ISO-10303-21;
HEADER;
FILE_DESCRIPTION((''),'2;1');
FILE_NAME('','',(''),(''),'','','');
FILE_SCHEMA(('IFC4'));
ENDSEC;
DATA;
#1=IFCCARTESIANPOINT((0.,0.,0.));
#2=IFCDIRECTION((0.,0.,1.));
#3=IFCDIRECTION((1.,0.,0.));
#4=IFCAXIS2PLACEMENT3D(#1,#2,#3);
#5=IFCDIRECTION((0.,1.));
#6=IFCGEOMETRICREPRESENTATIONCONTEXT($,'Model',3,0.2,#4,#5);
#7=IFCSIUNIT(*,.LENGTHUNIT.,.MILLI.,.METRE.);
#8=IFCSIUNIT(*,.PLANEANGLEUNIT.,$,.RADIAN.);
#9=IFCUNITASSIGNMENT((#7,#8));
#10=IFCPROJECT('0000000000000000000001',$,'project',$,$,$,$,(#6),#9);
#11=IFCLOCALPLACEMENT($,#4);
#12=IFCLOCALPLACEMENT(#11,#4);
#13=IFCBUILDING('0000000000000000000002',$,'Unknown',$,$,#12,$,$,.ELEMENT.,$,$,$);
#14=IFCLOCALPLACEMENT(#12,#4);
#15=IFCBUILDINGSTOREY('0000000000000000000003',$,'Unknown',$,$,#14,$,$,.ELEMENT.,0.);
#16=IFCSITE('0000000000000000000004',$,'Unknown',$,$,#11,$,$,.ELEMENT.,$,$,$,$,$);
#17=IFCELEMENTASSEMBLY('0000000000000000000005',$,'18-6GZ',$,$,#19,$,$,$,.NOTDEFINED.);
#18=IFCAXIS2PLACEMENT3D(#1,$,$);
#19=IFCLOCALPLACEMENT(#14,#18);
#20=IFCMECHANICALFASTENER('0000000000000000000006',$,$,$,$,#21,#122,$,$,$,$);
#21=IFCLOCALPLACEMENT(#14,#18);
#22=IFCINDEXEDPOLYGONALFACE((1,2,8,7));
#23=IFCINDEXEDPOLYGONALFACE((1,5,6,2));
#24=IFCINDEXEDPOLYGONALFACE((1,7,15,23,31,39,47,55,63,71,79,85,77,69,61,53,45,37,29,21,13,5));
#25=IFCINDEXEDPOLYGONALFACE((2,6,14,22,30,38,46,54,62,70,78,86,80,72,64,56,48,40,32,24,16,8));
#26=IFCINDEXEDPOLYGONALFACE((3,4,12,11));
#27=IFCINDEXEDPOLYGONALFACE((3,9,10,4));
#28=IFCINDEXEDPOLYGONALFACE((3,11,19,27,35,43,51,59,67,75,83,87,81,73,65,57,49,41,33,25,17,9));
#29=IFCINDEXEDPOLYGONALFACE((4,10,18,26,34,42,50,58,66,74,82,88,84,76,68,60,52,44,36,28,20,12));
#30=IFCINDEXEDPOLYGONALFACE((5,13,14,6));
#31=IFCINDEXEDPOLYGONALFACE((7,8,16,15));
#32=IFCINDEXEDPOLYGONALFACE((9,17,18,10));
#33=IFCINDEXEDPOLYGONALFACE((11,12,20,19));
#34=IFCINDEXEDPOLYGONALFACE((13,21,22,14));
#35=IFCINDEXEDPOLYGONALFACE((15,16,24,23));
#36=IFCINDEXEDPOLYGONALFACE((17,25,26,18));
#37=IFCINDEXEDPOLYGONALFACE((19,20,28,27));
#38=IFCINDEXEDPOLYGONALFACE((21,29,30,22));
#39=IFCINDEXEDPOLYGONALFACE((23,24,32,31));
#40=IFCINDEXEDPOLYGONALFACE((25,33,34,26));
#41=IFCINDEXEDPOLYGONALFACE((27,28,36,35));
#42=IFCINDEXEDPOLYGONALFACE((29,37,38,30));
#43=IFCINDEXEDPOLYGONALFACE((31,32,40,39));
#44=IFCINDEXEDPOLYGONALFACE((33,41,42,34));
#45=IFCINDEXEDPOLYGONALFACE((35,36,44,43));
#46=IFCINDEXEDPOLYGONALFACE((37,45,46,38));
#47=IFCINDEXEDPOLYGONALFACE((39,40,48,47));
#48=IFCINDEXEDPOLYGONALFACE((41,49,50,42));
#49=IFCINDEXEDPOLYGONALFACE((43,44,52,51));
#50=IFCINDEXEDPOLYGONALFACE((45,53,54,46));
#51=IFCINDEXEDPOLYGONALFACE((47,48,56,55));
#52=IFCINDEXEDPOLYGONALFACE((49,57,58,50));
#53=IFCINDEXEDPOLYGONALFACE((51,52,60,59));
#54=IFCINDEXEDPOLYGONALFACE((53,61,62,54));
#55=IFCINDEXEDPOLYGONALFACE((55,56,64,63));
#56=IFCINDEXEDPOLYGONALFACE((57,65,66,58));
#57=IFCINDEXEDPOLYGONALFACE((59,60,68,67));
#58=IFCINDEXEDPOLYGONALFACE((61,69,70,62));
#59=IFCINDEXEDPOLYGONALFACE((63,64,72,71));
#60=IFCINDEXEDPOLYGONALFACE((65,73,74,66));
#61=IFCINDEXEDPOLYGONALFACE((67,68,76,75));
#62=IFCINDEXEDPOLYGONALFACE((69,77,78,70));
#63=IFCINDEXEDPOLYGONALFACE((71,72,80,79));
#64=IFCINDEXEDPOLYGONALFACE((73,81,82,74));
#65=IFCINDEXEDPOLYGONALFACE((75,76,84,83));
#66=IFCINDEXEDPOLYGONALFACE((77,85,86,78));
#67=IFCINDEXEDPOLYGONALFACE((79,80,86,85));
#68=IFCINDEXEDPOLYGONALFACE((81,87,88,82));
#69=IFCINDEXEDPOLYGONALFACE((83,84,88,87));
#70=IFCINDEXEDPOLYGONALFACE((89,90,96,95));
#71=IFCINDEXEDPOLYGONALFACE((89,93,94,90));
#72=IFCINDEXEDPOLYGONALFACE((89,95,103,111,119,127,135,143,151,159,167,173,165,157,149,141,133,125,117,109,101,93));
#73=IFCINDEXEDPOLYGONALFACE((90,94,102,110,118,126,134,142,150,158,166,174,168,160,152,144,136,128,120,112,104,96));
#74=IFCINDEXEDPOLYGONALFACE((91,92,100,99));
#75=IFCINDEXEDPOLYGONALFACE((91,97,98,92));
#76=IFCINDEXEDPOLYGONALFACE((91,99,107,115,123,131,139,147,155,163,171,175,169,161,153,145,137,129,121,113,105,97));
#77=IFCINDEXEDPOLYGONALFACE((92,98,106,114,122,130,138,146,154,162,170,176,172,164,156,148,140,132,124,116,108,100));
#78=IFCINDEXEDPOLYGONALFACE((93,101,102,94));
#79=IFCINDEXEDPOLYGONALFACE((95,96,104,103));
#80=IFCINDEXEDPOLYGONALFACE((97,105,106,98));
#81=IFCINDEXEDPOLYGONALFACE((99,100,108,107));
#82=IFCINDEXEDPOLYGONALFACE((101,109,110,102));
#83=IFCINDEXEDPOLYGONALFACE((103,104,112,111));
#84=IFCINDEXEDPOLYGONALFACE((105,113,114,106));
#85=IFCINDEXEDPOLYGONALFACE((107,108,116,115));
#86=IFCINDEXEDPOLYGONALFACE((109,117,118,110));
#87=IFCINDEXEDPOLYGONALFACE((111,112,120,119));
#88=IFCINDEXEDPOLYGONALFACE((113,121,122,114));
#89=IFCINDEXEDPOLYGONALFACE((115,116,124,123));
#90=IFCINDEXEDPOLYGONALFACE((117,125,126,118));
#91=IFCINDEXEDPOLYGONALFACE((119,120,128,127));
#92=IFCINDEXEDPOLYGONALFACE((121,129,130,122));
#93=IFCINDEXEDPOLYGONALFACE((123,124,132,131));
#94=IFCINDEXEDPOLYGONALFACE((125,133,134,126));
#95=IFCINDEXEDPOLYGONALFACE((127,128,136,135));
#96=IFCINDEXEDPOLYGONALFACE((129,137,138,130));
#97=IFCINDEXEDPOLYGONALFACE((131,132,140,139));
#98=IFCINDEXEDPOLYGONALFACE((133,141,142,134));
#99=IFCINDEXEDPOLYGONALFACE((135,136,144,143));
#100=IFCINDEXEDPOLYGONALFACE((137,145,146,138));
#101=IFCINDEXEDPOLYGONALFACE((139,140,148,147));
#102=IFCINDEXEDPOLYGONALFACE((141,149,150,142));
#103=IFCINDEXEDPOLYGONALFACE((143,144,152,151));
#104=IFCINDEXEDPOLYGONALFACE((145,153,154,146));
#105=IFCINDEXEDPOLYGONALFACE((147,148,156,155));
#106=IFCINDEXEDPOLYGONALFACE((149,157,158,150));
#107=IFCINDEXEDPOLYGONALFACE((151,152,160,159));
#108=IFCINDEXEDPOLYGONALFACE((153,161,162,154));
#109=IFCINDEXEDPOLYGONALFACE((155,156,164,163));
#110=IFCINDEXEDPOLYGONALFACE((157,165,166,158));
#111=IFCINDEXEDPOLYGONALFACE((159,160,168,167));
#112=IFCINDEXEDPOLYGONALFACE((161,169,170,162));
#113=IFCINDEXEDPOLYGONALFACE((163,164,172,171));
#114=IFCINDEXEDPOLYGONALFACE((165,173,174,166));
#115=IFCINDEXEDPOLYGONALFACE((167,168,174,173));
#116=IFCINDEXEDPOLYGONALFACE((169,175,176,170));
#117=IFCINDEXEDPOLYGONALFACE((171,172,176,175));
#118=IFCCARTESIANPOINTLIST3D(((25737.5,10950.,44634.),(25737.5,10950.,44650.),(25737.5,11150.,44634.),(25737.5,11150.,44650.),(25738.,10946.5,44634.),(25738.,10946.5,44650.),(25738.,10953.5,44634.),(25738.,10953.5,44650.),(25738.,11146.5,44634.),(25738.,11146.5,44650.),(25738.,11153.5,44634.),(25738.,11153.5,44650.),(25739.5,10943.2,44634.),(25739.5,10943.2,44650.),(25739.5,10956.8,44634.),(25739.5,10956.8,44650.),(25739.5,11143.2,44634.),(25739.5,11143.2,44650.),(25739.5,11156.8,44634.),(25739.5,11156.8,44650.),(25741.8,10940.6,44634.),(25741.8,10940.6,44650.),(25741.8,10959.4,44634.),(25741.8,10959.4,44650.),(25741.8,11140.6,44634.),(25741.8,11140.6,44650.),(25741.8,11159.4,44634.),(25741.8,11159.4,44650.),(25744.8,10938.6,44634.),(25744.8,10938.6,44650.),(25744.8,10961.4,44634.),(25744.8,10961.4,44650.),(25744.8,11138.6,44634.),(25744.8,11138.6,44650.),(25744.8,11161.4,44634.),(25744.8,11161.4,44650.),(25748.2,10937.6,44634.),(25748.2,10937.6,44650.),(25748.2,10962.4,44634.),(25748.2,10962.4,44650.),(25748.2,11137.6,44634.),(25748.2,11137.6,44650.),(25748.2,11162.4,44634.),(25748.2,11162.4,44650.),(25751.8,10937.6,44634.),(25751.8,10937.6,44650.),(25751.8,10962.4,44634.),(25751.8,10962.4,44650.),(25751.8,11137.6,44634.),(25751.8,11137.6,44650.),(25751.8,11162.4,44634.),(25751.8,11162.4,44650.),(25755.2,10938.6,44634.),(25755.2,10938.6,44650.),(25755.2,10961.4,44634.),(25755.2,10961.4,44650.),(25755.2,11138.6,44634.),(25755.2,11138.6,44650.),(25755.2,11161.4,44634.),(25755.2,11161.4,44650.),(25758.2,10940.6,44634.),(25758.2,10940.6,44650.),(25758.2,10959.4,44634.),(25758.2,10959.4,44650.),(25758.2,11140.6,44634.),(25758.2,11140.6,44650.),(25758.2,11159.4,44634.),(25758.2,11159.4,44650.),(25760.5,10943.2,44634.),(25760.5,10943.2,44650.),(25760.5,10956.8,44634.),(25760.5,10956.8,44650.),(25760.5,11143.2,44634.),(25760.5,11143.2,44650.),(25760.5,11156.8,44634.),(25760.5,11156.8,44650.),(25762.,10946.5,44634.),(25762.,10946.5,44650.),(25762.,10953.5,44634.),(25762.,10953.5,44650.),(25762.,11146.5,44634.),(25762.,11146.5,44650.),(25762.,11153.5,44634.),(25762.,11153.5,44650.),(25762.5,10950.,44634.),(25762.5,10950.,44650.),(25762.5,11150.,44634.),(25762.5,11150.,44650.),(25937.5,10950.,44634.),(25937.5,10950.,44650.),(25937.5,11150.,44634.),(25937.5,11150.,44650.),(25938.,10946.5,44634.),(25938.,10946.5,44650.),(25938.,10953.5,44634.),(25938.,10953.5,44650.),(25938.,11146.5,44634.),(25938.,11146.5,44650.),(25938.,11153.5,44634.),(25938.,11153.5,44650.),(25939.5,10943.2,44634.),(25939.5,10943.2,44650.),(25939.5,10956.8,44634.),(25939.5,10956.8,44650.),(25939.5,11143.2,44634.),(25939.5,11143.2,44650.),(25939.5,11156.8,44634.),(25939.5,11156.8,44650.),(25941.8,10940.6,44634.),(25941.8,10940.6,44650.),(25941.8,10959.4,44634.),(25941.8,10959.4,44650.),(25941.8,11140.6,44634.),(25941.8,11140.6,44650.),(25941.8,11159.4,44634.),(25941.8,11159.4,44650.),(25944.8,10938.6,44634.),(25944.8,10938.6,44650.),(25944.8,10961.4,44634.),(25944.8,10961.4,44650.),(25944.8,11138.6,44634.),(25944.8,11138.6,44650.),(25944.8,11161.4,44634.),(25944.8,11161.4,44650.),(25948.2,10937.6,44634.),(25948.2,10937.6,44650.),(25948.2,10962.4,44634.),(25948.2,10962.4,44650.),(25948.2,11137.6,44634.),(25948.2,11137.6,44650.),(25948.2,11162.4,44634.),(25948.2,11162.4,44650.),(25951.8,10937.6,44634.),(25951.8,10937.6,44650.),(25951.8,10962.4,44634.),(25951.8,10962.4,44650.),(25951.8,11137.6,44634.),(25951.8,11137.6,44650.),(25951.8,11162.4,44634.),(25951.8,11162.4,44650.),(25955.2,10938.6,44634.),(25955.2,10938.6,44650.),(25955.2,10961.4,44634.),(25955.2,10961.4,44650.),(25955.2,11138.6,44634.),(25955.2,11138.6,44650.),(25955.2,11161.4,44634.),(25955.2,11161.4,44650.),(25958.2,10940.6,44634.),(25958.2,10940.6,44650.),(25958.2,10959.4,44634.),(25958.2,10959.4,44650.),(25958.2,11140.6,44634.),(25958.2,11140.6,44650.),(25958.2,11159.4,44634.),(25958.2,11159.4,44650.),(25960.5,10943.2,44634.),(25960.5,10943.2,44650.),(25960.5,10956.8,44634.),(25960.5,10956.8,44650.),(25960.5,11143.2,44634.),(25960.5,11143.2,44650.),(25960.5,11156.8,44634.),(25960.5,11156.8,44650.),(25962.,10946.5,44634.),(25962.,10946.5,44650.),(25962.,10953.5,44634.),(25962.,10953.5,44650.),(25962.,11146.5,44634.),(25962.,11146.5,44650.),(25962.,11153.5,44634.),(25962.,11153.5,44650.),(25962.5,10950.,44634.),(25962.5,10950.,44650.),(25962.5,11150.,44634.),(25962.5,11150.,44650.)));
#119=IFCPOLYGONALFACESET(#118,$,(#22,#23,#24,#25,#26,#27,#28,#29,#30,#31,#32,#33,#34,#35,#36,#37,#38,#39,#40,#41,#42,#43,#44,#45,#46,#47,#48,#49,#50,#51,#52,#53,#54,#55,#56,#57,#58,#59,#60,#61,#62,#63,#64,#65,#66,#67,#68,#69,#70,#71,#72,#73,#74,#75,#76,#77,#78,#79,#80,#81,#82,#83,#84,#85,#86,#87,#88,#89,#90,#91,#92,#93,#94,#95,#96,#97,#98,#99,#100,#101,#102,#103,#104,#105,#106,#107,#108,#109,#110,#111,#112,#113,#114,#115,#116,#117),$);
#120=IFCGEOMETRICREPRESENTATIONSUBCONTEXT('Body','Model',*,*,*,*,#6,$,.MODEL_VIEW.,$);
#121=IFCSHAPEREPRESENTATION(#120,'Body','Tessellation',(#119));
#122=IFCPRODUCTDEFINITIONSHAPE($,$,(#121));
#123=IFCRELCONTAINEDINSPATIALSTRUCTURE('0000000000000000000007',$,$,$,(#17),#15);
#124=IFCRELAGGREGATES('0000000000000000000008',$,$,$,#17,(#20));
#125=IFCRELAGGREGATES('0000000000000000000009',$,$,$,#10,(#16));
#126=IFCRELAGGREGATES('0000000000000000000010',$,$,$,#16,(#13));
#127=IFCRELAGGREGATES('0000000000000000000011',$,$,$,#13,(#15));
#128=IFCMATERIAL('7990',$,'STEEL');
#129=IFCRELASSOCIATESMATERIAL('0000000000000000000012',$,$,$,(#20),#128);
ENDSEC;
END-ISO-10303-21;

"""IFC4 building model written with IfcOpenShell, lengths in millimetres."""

from ifc_helpers import new_model, si_unit, direction, frame, origin_with_axes, place, context, subcontext, project, spatial, arc, indexed_curve, outline, extrude, source, transform, mapped, material, element, aggregate, save


model = new_model("IFC4")

# Units and contexts
model_context = context("Model", 3, precision=0.2, world=origin_with_axes(), true_north=direction((0.0, 1.0)))
body_context = subcontext(model_context, "Body", "Model", "MODEL_VIEW")
ifc_project = project(units=[si_unit("LENGTHUNIT", "METRE", prefix="MILLI"), si_unit("PLANEANGLEUNIT", "RADIAN")], contexts=[model_context])

# Site, building, storey
site_placement = place(None, origin_with_axes())
site = spatial("IfcSite", under=ifc_project, at=site_placement, Name="Unknown", CompositionType="ELEMENT")
building_placement = place(site_placement, origin_with_axes())
building = spatial("IfcBuilding", under=site, at=building_placement, Name="Unknown", CompositionType="ELEMENT")
storey_placement = place(building_placement, origin_with_axes())
storey = spatial("IfcBuildingStorey", under=building, at=storey_placement, Name="Unknown", CompositionType="ELEMENT", Elevation=0.0)

# Element assembly
assembly_1_placement = place(storey_placement, frame((25850.0, 11050.0, 35950.0), z_axis=(-1.0, 0.0, 0.0), x_axis=(0.0, 0.0, 1.0)))
assembly_1 = element("IfcElementAssembly", 1, at=assembly_1_placement, inside=storey, Name="18-6GZ", PredefinedType="NOTDEFINED")

# Mechanical fastener
ifc_material_1 = material(Name="7990", Category="STEEL")
placement_1 = place(assembly_1_placement, frame((8684.0, 0.0, 0.0), z_axis=(-1.0, 0.0, 0.0), x_axis=(0.0, 1.0, 0.0)))
shared_shape_1 = source(origin_with_axes(), body_context, "Body", "SweptSolid", [
    extrude(outline(indexed_curve([(12.5, 0.0), (0.0, 12.5), (-12.5, 0.0), (0.0, -12.5)], segments=[arc(1, 2, 3), arc(3, 4, 1)])), frame((0.0, 0.0, 0.0), z_axis=(0.0, 0.0, -1.0), x_axis=(0.0, 1.0, 0.0)), (0.0, 0.0, 1.0), 16.0),
])
mechanical_fastener_1 = element("IfcMechanicalFastener", 2, at=placement_1, material=ifc_material_1, context=body_context, shape_type="MappedRepresentation", body=[
    mapped(shared_shape_1, transform((-100.0, -100.0, 0.0))),
    mapped(shared_shape_1, transform((100.0, -100.0, 0.0))),
    mapped(shared_shape_1, transform((-100.0, 100.0, 0.0))),
    mapped(shared_shape_1, transform((100.0, 100.0, 0.0))),
])
aggregate(assembly_1, [mechanical_fastener_1])

save(model, "model.ifc")
